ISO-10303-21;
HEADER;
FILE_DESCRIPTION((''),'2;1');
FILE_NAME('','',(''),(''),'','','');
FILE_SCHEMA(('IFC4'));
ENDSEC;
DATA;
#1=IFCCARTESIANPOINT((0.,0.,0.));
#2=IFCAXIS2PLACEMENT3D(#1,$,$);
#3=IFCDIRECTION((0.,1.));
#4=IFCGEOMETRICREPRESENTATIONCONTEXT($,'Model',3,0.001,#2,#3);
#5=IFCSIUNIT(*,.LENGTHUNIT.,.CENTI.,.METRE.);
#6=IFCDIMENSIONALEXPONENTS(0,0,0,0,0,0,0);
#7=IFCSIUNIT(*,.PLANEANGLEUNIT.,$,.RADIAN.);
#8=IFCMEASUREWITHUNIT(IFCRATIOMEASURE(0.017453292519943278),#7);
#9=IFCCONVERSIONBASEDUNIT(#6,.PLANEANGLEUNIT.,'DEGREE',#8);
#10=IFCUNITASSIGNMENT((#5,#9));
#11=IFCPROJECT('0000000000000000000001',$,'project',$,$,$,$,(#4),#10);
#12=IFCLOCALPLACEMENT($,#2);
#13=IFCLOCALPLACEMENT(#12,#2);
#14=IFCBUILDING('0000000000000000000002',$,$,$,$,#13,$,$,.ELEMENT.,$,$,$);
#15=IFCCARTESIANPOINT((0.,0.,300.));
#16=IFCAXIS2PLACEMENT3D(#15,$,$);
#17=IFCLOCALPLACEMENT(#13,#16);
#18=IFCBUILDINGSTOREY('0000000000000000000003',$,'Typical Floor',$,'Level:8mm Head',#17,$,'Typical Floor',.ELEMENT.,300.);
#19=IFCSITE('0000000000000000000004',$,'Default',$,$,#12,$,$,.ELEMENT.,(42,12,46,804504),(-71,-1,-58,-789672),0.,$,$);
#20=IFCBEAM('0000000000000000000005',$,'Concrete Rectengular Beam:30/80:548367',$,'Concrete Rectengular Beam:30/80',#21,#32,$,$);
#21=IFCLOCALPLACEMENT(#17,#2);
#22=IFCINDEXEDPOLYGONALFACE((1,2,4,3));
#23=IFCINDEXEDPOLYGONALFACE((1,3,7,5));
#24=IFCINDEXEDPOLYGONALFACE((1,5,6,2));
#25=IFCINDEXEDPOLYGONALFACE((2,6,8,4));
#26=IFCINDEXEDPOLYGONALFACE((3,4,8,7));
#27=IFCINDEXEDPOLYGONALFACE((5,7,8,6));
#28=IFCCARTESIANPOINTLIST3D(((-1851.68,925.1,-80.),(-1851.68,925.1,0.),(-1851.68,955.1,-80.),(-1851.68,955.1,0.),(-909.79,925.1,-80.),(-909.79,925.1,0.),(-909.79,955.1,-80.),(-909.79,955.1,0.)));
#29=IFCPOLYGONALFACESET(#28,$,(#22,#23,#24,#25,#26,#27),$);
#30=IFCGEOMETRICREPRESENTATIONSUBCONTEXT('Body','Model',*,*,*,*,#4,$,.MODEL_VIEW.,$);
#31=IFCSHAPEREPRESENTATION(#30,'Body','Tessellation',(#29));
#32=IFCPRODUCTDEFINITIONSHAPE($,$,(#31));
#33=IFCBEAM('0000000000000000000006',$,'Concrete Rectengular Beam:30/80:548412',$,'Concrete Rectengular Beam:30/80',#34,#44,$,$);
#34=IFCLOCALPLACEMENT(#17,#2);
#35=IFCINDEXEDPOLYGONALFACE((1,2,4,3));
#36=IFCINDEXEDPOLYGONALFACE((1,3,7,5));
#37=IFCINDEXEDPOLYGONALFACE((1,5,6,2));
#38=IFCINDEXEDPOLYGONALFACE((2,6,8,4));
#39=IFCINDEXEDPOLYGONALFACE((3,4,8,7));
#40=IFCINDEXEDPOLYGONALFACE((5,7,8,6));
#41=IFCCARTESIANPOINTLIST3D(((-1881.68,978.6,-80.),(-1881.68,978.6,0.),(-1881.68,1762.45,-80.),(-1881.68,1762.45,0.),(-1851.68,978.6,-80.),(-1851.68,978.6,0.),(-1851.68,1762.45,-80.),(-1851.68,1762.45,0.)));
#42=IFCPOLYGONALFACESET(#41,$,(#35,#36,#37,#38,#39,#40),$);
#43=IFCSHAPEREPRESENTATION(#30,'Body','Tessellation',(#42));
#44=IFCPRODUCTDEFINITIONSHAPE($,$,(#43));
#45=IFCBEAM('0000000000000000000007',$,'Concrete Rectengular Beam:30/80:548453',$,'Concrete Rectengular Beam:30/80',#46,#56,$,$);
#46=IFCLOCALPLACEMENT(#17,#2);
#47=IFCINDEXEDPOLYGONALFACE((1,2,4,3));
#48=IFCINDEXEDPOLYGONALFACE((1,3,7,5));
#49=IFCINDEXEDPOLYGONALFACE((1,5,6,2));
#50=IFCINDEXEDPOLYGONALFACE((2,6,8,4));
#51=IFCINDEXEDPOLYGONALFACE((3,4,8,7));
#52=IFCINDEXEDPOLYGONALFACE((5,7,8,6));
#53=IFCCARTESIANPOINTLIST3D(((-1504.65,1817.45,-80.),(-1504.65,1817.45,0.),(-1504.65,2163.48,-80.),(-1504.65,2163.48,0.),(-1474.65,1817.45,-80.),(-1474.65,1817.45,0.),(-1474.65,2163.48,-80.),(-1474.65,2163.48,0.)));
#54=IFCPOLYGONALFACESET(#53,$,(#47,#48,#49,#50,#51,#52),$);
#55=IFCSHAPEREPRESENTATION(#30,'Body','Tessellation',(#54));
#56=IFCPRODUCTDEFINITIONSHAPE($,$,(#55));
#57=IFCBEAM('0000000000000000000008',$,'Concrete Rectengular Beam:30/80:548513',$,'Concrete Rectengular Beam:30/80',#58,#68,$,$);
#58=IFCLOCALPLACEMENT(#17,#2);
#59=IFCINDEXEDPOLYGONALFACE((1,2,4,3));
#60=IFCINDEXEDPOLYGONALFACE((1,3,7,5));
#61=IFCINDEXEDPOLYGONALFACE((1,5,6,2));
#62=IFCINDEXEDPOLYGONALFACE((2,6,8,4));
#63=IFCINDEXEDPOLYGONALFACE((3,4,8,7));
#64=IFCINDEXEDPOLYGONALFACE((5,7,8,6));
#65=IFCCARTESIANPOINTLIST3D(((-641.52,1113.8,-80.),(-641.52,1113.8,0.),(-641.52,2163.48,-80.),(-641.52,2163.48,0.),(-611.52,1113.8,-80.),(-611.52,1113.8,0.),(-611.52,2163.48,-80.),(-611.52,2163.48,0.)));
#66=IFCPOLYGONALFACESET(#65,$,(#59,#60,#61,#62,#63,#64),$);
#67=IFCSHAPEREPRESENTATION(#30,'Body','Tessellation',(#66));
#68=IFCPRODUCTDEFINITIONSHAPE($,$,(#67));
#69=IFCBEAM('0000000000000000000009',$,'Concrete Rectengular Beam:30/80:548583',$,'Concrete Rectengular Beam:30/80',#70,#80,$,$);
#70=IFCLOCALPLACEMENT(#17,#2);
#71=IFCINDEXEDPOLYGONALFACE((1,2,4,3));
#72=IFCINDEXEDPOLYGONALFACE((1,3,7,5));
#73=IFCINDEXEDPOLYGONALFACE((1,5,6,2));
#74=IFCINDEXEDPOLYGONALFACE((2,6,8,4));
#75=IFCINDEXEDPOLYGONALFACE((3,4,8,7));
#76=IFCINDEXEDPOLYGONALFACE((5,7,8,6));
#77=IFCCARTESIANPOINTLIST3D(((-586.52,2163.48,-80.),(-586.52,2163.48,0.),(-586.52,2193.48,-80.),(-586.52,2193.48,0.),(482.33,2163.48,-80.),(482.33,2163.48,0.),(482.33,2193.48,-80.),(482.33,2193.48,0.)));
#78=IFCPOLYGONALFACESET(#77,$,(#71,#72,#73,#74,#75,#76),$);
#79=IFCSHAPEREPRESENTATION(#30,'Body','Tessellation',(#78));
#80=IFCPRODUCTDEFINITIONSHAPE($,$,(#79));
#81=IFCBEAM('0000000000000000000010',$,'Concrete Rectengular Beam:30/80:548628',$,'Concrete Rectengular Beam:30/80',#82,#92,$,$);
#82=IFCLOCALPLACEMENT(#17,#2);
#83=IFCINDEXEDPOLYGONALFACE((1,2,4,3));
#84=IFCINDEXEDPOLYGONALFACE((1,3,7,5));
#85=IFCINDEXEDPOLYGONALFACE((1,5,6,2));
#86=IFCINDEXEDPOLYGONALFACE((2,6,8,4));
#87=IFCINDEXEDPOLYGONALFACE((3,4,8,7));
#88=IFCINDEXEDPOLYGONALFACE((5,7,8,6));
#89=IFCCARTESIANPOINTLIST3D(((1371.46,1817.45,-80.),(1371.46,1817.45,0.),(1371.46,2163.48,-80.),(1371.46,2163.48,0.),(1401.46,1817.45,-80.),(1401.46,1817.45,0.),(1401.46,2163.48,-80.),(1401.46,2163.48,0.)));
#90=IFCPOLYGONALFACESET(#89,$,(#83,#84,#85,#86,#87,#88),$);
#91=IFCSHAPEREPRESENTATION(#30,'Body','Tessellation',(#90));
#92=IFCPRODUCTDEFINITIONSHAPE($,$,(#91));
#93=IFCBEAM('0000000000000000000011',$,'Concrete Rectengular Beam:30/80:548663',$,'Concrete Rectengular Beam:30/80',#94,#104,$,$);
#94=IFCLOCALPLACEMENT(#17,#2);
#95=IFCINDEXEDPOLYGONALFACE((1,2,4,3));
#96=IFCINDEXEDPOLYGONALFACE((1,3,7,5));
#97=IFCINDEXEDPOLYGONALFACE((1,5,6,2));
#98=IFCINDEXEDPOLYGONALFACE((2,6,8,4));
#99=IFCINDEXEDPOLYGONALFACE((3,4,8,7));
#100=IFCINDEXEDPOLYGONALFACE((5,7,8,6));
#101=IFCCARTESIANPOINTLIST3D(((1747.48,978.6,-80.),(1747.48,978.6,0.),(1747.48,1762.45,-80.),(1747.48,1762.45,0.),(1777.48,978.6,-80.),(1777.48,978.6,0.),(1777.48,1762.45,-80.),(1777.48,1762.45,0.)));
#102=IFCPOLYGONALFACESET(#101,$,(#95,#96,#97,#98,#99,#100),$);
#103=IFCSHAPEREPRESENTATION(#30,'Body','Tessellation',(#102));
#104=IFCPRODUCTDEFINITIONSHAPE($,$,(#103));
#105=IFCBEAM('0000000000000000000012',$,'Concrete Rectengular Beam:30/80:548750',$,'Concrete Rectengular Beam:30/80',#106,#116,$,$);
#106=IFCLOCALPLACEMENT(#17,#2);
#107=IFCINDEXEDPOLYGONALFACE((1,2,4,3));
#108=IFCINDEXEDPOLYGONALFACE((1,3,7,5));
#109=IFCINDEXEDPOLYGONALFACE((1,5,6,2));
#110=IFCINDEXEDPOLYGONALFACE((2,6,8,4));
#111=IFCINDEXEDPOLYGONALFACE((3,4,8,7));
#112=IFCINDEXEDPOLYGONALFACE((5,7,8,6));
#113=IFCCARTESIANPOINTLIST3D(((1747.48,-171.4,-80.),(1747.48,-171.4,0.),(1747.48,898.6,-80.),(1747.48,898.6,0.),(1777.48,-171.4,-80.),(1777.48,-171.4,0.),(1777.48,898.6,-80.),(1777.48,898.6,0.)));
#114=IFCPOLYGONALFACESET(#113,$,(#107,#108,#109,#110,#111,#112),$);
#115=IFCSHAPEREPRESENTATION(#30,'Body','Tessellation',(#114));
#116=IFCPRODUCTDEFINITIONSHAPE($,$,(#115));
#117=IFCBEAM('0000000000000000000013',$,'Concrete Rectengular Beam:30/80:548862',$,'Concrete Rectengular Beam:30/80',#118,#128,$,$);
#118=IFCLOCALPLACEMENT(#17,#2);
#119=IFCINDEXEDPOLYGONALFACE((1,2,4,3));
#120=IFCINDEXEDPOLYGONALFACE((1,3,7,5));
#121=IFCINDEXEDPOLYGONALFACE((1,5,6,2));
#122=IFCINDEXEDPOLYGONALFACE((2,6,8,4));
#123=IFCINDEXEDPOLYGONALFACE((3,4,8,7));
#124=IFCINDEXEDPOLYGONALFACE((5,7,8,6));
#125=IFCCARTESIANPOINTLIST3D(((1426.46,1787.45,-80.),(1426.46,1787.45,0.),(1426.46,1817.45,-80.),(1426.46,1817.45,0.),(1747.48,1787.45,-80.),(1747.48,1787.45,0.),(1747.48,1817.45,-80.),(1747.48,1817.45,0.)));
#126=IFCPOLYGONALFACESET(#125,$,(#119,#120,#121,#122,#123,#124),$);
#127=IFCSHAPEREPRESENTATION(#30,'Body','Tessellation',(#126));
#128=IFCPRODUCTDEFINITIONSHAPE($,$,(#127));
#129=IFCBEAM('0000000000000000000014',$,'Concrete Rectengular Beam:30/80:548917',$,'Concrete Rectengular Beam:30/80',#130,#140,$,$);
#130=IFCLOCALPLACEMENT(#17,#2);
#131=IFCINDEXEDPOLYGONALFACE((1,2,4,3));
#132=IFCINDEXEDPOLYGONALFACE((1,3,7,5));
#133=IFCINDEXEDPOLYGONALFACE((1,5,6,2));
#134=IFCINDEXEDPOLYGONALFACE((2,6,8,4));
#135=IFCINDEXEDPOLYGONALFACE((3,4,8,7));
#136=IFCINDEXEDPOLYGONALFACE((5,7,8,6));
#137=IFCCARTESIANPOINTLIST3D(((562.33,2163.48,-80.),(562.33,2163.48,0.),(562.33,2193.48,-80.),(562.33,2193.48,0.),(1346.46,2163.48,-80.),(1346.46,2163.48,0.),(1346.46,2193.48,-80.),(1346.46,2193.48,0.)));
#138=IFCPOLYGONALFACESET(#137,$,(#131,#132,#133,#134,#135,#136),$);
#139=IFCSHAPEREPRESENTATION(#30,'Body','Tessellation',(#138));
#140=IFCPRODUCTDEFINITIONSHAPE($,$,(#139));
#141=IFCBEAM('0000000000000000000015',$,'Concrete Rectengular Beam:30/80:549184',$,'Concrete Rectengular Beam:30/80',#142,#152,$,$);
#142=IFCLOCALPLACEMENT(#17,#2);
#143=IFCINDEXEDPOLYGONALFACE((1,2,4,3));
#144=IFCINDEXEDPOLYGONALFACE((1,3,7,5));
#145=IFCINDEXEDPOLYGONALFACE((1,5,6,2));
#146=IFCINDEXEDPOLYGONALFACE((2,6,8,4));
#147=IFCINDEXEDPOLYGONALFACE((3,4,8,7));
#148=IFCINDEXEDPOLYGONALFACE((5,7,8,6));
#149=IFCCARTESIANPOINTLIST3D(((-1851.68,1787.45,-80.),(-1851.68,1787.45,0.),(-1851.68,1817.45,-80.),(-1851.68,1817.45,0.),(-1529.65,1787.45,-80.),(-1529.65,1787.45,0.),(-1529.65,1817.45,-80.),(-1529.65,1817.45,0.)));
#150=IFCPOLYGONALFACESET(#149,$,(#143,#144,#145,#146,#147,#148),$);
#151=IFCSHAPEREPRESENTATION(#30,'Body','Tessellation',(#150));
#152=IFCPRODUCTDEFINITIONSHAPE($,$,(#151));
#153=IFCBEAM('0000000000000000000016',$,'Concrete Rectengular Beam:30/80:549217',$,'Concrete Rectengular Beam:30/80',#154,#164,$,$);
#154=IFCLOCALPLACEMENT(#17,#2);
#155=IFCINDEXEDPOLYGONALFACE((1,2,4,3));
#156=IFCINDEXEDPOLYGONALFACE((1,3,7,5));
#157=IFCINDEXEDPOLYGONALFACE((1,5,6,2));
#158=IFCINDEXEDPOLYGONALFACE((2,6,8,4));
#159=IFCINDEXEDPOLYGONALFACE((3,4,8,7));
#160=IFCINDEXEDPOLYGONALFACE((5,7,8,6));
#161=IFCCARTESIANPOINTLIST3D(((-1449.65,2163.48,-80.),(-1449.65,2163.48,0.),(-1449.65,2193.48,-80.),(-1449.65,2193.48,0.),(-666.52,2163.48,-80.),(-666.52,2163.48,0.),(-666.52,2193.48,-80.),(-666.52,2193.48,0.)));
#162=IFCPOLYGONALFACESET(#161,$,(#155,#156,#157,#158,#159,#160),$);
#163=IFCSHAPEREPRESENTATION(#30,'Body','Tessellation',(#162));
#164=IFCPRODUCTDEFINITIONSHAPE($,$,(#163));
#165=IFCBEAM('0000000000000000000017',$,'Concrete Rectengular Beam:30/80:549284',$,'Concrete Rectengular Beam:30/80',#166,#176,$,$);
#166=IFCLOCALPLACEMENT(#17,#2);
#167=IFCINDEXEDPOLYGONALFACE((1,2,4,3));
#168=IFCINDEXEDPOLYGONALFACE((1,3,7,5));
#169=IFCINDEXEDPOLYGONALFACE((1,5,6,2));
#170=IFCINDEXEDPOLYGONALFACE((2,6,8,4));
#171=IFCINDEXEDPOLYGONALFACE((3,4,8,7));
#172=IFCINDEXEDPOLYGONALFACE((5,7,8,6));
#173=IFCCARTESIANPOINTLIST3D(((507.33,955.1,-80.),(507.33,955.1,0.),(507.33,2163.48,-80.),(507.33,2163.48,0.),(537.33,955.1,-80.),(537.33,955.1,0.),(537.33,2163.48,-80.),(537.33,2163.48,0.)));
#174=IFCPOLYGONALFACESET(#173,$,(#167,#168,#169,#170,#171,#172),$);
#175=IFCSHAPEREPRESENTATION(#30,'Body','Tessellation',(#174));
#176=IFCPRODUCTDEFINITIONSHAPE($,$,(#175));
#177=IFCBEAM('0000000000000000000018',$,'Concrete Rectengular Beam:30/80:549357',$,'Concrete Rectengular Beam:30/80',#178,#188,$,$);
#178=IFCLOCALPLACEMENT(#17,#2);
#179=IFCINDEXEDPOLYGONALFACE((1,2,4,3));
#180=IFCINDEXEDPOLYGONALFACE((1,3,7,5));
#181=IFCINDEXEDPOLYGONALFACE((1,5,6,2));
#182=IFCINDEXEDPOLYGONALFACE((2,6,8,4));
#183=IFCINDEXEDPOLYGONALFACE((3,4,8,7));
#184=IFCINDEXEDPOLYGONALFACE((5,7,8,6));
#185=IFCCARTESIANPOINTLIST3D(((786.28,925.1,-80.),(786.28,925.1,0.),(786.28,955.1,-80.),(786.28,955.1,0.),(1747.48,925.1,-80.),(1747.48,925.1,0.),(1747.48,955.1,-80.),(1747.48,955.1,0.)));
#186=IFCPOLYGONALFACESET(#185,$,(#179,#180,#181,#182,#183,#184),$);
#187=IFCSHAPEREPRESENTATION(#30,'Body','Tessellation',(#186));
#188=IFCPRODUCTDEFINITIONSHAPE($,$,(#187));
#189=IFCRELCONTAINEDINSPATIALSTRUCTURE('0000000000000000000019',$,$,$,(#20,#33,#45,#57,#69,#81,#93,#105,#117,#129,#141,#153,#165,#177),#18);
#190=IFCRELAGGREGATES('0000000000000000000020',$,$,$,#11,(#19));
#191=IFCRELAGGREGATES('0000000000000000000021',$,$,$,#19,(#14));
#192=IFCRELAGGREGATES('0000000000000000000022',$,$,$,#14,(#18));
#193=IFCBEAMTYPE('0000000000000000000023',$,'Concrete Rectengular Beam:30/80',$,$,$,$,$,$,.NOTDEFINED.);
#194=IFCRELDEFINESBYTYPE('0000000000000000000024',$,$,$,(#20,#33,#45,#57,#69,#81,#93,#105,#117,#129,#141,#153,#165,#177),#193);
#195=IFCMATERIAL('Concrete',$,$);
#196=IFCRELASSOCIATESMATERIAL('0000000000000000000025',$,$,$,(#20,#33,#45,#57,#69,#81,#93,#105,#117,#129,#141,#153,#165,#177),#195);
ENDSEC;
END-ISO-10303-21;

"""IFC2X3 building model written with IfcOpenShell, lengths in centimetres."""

from ifc_helpers import new_model, entity, si_unit, converted_unit, direction, frame, frame_2d, origin, origin_2d_with_axis, place, context, subcontext, project, spatial, rectangle, extrude, material, type_object, element, save


model = new_model("IFC2X3")

# Units and contexts
model_context = context("Model", 3, precision=0.001, world=origin(), true_north=direction((0.0, 1.0)))
body_context = subcontext(model_context, "Body", "Model", "MODEL_VIEW")
ifc_project = project(units=[si_unit("LENGTHUNIT", "METRE", prefix="CENTI"), converted_unit("PLANEANGLEUNIT", "DEGREE", entity("IfcRatioMeasure", 0.017453292519943278), si_unit("PLANEANGLEUNIT", "RADIAN"), dimensions=[0, 0, 0, 0, 0, 0, 0])], contexts=[model_context])

# Site, building, storey
site_placement = place(None, origin())
site = spatial("IfcSite", under=ifc_project, at=site_placement, Name="Default", CompositionType="ELEMENT", RefLatitude=(42, 12, 46, 804504), RefLongitude=(-71, -1, -58, -789672), RefElevation=0.0)
building_placement = place(site_placement, origin())
building = spatial("IfcBuilding", under=site, at=building_placement, CompositionType="ELEMENT")
storey_placement = place(building_placement, frame((0.0, 0.0, 300.0)))
storey = spatial("IfcBuildingStorey", under=building, at=storey_placement, Name="Typical Floor", ObjectType="Level:8mm Head", LongName="Typical Floor", CompositionType="ELEMENT", Elevation=300.0)

# Beams
ifc_material = material(Name="Concrete")
beam_type = type_object("IfcBeamType", Name="Concrete Rectengular Beam:30/80", PredefinedType="NOTDEFINED")
beam_1_placement = place(storey_placement, frame((-1866.68, 940.1, 0.0)))
element("IfcBeam", 1, at=beam_1_placement, inside=storey, type_object=beam_type, material=ifc_material, Name="Concrete Rectengular Beam:30/80:548367", ObjectType="Concrete Rectengular Beam:30/80", context=body_context, shape_type="SweptSolid", body=[
    extrude(rectangle(XDim=80.0, YDim=30.0, at=frame_2d((0.0, 0.0), x_axis=(1.0, 0.0))), frame((15.0, 0.0, -40.0), z_axis=(1.0, 0.0, 0.0), x_axis=(0.0, 0.0, -1.0)), (0.0, 0.0, 1.0), 941.89),
])
beam_2_placement = place(storey_placement, frame((-1866.68, 938.6, 0.0), z_axis=(0.0, 0.0, 1.0), x_axis=(0.0, 1.0, 0.0)))
element("IfcBeam", 2, at=beam_2_placement, inside=storey, type_object=beam_type, material=ifc_material, Name="Concrete Rectengular Beam:30/80:548412", ObjectType="Concrete Rectengular Beam:30/80", context=body_context, shape_type="SweptSolid", body=[
    extrude(rectangle(XDim=80.0, YDim=30.0, at=frame_2d((0.0, 0.0), x_axis=(1.0, 0.0))), frame((40.0, 0.0, -40.0), z_axis=(1.0, 0.0, 0.0), x_axis=(0.0, 0.0, -1.0)), (0.0, 0.0, 1.0), 783.85),
])
beam_3_placement = place(storey_placement, frame((-1489.65, 1802.45, 0.0), z_axis=(0.0, 0.0, 1.0), x_axis=(0.0, 1.0, 0.0)))
element("IfcBeam", 3, at=beam_3_placement, inside=storey, type_object=beam_type, material=ifc_material, Name="Concrete Rectengular Beam:30/80:548453", ObjectType="Concrete Rectengular Beam:30/80", context=body_context, shape_type="SweptSolid", body=[
    extrude(rectangle(XDim=80.0, YDim=30.0, at=frame_2d((0.0, 0.0), x_axis=(1.0, 0.0))), frame((15.0, 0.0, -40.0), z_axis=(1.0, 0.0, 0.0), x_axis=(0.0, 0.0, -1.0)), (0.0, 0.0, 1.0), 346.03),
])
beam_4_placement = place(storey_placement, frame((-626.52, 2178.48, 0.0), z_axis=(0.0, 0.0, 1.0), x_axis=(0.0, -1.0, 0.0)))
element("IfcBeam", 4, at=beam_4_placement, inside=storey, type_object=beam_type, material=ifc_material, Name="Concrete Rectengular Beam:30/80:548513", ObjectType="Concrete Rectengular Beam:30/80", context=body_context, shape_type="SweptSolid", body=[
    extrude(rectangle(XDim=80.0, YDim=30.0, at=frame_2d((0.0, 0.0), x_axis=(1.0, 0.0))), frame((15.0, 0.0, -40.0), z_axis=(1.0, 0.0, 0.0), x_axis=(0.0, 0.0, -1.0)), (0.0, 0.0, 1.0), 1049.68),
])
beam_5_placement = place(storey_placement, frame((-626.52, 2178.48, 0.0)))
element("IfcBeam", 5, at=beam_5_placement, inside=storey, type_object=beam_type, material=ifc_material, Name="Concrete Rectengular Beam:30/80:548583", ObjectType="Concrete Rectengular Beam:30/80", context=body_context, shape_type="SweptSolid", body=[
    extrude(rectangle(XDim=80.0, YDim=30.0, at=frame_2d((0.0, 0.0), x_axis=(1.0, 0.0))), frame((40.0, 0.0, -40.0), z_axis=(1.0, 0.0, 0.0), x_axis=(0.0, 0.0, -1.0)), (0.0, 0.0, 1.0), 1068.85),
])
beam_6_placement = place(storey_placement, frame((1386.46, 2178.48, 0.0), z_axis=(0.0, 0.0, 1.0), x_axis=(0.0, -1.0, 0.0)))
element("IfcBeam", 6, at=beam_6_placement, inside=storey, type_object=beam_type, material=ifc_material, Name="Concrete Rectengular Beam:30/80:548628", ObjectType="Concrete Rectengular Beam:30/80", context=body_context, shape_type="SweptSolid", body=[
    extrude(rectangle(XDim=80.0, YDim=30.0, at=frame_2d((0.0, 0.0), x_axis=(1.0, 0.0))), frame((15.0, 0.0, -40.0), z_axis=(1.0, 0.0, 0.0), x_axis=(0.0, 0.0, -1.0)), (0.0, 0.0, 1.0), 346.03),
])
beam_7_placement = place(storey_placement, frame((1762.48, 1802.45, 0.0), z_axis=(0.0, 0.0, 1.0), x_axis=(0.0, -1.0, 0.0)))
element("IfcBeam", 7, at=beam_7_placement, inside=storey, type_object=beam_type, material=ifc_material, Name="Concrete Rectengular Beam:30/80:548663", ObjectType="Concrete Rectengular Beam:30/80", context=body_context, shape_type="SweptSolid", body=[
    extrude(rectangle(XDim=80.0, YDim=30.0, at=origin_2d_with_axis()), frame((40.0, 0.0, -40.0), z_axis=(1.0, 0.0, 0.0), x_axis=(0.0, 0.0, -1.0)), (0.0, 0.0, 1.0), 783.85),
])
beam_8_placement = place(storey_placement, frame((1762.48, 938.6, 0.0), z_axis=(0.0, 0.0, 1.0), x_axis=(0.0, -1.0, 0.0)))
element("IfcBeam", 8, at=beam_8_placement, inside=storey, type_object=beam_type, material=ifc_material, Name="Concrete Rectengular Beam:30/80:548750", ObjectType="Concrete Rectengular Beam:30/80", context=body_context, shape_type="SweptSolid", body=[
    extrude(rectangle(XDim=80.0, YDim=30.0, at=origin_2d_with_axis()), frame((40.0, 0.0, -40.0), z_axis=(1.0, 0.0, 0.0), x_axis=(0.0, 0.0, -1.0)), (0.0, 0.0, 1.0), 1070.0),
])
beam_9_placement = place(storey_placement, frame((1762.48, 1802.45, 0.0), z_axis=(0.0, 0.0, 1.0), x_axis=(-1.0, 0.0, 0.0)))
element("IfcBeam", 9, at=beam_9_placement, inside=storey, type_object=beam_type, material=ifc_material, Name="Concrete Rectengular Beam:30/80:548862", ObjectType="Concrete Rectengular Beam:30/80", context=body_context, shape_type="SweptSolid", body=[
    extrude(rectangle(XDim=80.0, YDim=30.0, at=frame_2d((0.0, 0.0), x_axis=(1.0, 0.0))), frame((15.0, 0.0, -40.0), z_axis=(1.0, 0.0, 0.0), x_axis=(0.0, 0.0, -1.0)), (0.0, 0.0, 1.0), 321.02),
])
beam_10_placement = place(storey_placement, frame((1386.46, 2178.48, 0.0), z_axis=(0.0, 0.0, 1.0), x_axis=(-1.0, 0.0, 0.0)))
element("IfcBeam", 10, at=beam_10_placement, inside=storey, type_object=beam_type, material=ifc_material, Name="Concrete Rectengular Beam:30/80:548917", ObjectType="Concrete Rectengular Beam:30/80", context=body_context, shape_type="SweptSolid", body=[
    extrude(rectangle(XDim=80.0, YDim=30.0, at=frame_2d((0.0, 0.0), x_axis=(1.0, 0.0))), frame((40.0, 0.0, -40.0), z_axis=(1.0, 0.0, 0.0), x_axis=(0.0, 0.0, -1.0)), (0.0, 0.0, 1.0), 784.13),
])
beam_11_placement = place(storey_placement, frame((-1866.68, 1802.45, 0.0)))
element("IfcBeam", 11, at=beam_11_placement, inside=storey, type_object=beam_type, material=ifc_material, Name="Concrete Rectengular Beam:30/80:549184", ObjectType="Concrete Rectengular Beam:30/80", context=body_context, shape_type="SweptSolid", body=[
    extrude(rectangle(XDim=80.0, YDim=30.0, at=frame_2d((0.0, 0.0), x_axis=(1.0, 0.0))), frame((15.0, 0.0, -40.0), z_axis=(1.0, 0.0, 0.0), x_axis=(0.0, 0.0, -1.0)), (0.0, 0.0, 1.0), 322.02),
])
beam_12_placement = place(storey_placement, frame((-1489.65, 2178.48, 0.0)))
element("IfcBeam", 12, at=beam_12_placement, inside=storey, type_object=beam_type, material=ifc_material, Name="Concrete Rectengular Beam:30/80:549217", ObjectType="Concrete Rectengular Beam:30/80", context=body_context, shape_type="SweptSolid", body=[
    extrude(rectangle(XDim=80.0, YDim=30.0, at=frame_2d((0.0, 0.0), x_axis=(1.0, 0.0))), frame((40.0, 0.0, -40.0), z_axis=(1.0, 0.0, 0.0), x_axis=(0.0, 0.0, -1.0)), (0.0, 0.0, 1.0), 783.13),
])
beam_13_placement = place(storey_placement, frame((522.33, 2178.48, 0.0), z_axis=(0.0, 0.0, 1.0), x_axis=(0.0, -1.0, 0.0)))
element("IfcBeam", 13, at=beam_13_placement, inside=storey, type_object=beam_type, material=ifc_material, Name="Concrete Rectengular Beam:30/80:549284", ObjectType="Concrete Rectengular Beam:30/80", context=body_context, shape_type="SweptSolid", body=[
    extrude(rectangle(XDim=80.0, YDim=30.0, at=frame_2d((0.0, 0.0), x_axis=(1.0, 0.0))), frame((15.0, 0.0, -40.0), z_axis=(1.0, 0.0, 0.0), x_axis=(0.0, 0.0, -1.0)), (0.0, 0.0, 1.0), 1208.38),
])
beam_14_placement = place(storey_placement, frame((1762.48, 940.1, 0.0), z_axis=(0.0, 0.0, 1.0), x_axis=(-1.0, 0.0, 0.0)))
element("IfcBeam", 14, at=beam_14_placement, inside=storey, type_object=beam_type, material=ifc_material, Name="Concrete Rectengular Beam:30/80:549357", ObjectType="Concrete Rectengular Beam:30/80", context=body_context, shape_type="SweptSolid", body=[
    extrude(rectangle(XDim=80.0, YDim=30.0, at=frame_2d((0.0, 0.0), x_axis=(1.0, 0.0))), frame((15.0, 0.0, -40.0), z_axis=(1.0, 0.0, 0.0), x_axis=(0.0, 0.0, -1.0)), (0.0, 0.0, 1.0), 961.2),
])

save(model, "model.ifc")
